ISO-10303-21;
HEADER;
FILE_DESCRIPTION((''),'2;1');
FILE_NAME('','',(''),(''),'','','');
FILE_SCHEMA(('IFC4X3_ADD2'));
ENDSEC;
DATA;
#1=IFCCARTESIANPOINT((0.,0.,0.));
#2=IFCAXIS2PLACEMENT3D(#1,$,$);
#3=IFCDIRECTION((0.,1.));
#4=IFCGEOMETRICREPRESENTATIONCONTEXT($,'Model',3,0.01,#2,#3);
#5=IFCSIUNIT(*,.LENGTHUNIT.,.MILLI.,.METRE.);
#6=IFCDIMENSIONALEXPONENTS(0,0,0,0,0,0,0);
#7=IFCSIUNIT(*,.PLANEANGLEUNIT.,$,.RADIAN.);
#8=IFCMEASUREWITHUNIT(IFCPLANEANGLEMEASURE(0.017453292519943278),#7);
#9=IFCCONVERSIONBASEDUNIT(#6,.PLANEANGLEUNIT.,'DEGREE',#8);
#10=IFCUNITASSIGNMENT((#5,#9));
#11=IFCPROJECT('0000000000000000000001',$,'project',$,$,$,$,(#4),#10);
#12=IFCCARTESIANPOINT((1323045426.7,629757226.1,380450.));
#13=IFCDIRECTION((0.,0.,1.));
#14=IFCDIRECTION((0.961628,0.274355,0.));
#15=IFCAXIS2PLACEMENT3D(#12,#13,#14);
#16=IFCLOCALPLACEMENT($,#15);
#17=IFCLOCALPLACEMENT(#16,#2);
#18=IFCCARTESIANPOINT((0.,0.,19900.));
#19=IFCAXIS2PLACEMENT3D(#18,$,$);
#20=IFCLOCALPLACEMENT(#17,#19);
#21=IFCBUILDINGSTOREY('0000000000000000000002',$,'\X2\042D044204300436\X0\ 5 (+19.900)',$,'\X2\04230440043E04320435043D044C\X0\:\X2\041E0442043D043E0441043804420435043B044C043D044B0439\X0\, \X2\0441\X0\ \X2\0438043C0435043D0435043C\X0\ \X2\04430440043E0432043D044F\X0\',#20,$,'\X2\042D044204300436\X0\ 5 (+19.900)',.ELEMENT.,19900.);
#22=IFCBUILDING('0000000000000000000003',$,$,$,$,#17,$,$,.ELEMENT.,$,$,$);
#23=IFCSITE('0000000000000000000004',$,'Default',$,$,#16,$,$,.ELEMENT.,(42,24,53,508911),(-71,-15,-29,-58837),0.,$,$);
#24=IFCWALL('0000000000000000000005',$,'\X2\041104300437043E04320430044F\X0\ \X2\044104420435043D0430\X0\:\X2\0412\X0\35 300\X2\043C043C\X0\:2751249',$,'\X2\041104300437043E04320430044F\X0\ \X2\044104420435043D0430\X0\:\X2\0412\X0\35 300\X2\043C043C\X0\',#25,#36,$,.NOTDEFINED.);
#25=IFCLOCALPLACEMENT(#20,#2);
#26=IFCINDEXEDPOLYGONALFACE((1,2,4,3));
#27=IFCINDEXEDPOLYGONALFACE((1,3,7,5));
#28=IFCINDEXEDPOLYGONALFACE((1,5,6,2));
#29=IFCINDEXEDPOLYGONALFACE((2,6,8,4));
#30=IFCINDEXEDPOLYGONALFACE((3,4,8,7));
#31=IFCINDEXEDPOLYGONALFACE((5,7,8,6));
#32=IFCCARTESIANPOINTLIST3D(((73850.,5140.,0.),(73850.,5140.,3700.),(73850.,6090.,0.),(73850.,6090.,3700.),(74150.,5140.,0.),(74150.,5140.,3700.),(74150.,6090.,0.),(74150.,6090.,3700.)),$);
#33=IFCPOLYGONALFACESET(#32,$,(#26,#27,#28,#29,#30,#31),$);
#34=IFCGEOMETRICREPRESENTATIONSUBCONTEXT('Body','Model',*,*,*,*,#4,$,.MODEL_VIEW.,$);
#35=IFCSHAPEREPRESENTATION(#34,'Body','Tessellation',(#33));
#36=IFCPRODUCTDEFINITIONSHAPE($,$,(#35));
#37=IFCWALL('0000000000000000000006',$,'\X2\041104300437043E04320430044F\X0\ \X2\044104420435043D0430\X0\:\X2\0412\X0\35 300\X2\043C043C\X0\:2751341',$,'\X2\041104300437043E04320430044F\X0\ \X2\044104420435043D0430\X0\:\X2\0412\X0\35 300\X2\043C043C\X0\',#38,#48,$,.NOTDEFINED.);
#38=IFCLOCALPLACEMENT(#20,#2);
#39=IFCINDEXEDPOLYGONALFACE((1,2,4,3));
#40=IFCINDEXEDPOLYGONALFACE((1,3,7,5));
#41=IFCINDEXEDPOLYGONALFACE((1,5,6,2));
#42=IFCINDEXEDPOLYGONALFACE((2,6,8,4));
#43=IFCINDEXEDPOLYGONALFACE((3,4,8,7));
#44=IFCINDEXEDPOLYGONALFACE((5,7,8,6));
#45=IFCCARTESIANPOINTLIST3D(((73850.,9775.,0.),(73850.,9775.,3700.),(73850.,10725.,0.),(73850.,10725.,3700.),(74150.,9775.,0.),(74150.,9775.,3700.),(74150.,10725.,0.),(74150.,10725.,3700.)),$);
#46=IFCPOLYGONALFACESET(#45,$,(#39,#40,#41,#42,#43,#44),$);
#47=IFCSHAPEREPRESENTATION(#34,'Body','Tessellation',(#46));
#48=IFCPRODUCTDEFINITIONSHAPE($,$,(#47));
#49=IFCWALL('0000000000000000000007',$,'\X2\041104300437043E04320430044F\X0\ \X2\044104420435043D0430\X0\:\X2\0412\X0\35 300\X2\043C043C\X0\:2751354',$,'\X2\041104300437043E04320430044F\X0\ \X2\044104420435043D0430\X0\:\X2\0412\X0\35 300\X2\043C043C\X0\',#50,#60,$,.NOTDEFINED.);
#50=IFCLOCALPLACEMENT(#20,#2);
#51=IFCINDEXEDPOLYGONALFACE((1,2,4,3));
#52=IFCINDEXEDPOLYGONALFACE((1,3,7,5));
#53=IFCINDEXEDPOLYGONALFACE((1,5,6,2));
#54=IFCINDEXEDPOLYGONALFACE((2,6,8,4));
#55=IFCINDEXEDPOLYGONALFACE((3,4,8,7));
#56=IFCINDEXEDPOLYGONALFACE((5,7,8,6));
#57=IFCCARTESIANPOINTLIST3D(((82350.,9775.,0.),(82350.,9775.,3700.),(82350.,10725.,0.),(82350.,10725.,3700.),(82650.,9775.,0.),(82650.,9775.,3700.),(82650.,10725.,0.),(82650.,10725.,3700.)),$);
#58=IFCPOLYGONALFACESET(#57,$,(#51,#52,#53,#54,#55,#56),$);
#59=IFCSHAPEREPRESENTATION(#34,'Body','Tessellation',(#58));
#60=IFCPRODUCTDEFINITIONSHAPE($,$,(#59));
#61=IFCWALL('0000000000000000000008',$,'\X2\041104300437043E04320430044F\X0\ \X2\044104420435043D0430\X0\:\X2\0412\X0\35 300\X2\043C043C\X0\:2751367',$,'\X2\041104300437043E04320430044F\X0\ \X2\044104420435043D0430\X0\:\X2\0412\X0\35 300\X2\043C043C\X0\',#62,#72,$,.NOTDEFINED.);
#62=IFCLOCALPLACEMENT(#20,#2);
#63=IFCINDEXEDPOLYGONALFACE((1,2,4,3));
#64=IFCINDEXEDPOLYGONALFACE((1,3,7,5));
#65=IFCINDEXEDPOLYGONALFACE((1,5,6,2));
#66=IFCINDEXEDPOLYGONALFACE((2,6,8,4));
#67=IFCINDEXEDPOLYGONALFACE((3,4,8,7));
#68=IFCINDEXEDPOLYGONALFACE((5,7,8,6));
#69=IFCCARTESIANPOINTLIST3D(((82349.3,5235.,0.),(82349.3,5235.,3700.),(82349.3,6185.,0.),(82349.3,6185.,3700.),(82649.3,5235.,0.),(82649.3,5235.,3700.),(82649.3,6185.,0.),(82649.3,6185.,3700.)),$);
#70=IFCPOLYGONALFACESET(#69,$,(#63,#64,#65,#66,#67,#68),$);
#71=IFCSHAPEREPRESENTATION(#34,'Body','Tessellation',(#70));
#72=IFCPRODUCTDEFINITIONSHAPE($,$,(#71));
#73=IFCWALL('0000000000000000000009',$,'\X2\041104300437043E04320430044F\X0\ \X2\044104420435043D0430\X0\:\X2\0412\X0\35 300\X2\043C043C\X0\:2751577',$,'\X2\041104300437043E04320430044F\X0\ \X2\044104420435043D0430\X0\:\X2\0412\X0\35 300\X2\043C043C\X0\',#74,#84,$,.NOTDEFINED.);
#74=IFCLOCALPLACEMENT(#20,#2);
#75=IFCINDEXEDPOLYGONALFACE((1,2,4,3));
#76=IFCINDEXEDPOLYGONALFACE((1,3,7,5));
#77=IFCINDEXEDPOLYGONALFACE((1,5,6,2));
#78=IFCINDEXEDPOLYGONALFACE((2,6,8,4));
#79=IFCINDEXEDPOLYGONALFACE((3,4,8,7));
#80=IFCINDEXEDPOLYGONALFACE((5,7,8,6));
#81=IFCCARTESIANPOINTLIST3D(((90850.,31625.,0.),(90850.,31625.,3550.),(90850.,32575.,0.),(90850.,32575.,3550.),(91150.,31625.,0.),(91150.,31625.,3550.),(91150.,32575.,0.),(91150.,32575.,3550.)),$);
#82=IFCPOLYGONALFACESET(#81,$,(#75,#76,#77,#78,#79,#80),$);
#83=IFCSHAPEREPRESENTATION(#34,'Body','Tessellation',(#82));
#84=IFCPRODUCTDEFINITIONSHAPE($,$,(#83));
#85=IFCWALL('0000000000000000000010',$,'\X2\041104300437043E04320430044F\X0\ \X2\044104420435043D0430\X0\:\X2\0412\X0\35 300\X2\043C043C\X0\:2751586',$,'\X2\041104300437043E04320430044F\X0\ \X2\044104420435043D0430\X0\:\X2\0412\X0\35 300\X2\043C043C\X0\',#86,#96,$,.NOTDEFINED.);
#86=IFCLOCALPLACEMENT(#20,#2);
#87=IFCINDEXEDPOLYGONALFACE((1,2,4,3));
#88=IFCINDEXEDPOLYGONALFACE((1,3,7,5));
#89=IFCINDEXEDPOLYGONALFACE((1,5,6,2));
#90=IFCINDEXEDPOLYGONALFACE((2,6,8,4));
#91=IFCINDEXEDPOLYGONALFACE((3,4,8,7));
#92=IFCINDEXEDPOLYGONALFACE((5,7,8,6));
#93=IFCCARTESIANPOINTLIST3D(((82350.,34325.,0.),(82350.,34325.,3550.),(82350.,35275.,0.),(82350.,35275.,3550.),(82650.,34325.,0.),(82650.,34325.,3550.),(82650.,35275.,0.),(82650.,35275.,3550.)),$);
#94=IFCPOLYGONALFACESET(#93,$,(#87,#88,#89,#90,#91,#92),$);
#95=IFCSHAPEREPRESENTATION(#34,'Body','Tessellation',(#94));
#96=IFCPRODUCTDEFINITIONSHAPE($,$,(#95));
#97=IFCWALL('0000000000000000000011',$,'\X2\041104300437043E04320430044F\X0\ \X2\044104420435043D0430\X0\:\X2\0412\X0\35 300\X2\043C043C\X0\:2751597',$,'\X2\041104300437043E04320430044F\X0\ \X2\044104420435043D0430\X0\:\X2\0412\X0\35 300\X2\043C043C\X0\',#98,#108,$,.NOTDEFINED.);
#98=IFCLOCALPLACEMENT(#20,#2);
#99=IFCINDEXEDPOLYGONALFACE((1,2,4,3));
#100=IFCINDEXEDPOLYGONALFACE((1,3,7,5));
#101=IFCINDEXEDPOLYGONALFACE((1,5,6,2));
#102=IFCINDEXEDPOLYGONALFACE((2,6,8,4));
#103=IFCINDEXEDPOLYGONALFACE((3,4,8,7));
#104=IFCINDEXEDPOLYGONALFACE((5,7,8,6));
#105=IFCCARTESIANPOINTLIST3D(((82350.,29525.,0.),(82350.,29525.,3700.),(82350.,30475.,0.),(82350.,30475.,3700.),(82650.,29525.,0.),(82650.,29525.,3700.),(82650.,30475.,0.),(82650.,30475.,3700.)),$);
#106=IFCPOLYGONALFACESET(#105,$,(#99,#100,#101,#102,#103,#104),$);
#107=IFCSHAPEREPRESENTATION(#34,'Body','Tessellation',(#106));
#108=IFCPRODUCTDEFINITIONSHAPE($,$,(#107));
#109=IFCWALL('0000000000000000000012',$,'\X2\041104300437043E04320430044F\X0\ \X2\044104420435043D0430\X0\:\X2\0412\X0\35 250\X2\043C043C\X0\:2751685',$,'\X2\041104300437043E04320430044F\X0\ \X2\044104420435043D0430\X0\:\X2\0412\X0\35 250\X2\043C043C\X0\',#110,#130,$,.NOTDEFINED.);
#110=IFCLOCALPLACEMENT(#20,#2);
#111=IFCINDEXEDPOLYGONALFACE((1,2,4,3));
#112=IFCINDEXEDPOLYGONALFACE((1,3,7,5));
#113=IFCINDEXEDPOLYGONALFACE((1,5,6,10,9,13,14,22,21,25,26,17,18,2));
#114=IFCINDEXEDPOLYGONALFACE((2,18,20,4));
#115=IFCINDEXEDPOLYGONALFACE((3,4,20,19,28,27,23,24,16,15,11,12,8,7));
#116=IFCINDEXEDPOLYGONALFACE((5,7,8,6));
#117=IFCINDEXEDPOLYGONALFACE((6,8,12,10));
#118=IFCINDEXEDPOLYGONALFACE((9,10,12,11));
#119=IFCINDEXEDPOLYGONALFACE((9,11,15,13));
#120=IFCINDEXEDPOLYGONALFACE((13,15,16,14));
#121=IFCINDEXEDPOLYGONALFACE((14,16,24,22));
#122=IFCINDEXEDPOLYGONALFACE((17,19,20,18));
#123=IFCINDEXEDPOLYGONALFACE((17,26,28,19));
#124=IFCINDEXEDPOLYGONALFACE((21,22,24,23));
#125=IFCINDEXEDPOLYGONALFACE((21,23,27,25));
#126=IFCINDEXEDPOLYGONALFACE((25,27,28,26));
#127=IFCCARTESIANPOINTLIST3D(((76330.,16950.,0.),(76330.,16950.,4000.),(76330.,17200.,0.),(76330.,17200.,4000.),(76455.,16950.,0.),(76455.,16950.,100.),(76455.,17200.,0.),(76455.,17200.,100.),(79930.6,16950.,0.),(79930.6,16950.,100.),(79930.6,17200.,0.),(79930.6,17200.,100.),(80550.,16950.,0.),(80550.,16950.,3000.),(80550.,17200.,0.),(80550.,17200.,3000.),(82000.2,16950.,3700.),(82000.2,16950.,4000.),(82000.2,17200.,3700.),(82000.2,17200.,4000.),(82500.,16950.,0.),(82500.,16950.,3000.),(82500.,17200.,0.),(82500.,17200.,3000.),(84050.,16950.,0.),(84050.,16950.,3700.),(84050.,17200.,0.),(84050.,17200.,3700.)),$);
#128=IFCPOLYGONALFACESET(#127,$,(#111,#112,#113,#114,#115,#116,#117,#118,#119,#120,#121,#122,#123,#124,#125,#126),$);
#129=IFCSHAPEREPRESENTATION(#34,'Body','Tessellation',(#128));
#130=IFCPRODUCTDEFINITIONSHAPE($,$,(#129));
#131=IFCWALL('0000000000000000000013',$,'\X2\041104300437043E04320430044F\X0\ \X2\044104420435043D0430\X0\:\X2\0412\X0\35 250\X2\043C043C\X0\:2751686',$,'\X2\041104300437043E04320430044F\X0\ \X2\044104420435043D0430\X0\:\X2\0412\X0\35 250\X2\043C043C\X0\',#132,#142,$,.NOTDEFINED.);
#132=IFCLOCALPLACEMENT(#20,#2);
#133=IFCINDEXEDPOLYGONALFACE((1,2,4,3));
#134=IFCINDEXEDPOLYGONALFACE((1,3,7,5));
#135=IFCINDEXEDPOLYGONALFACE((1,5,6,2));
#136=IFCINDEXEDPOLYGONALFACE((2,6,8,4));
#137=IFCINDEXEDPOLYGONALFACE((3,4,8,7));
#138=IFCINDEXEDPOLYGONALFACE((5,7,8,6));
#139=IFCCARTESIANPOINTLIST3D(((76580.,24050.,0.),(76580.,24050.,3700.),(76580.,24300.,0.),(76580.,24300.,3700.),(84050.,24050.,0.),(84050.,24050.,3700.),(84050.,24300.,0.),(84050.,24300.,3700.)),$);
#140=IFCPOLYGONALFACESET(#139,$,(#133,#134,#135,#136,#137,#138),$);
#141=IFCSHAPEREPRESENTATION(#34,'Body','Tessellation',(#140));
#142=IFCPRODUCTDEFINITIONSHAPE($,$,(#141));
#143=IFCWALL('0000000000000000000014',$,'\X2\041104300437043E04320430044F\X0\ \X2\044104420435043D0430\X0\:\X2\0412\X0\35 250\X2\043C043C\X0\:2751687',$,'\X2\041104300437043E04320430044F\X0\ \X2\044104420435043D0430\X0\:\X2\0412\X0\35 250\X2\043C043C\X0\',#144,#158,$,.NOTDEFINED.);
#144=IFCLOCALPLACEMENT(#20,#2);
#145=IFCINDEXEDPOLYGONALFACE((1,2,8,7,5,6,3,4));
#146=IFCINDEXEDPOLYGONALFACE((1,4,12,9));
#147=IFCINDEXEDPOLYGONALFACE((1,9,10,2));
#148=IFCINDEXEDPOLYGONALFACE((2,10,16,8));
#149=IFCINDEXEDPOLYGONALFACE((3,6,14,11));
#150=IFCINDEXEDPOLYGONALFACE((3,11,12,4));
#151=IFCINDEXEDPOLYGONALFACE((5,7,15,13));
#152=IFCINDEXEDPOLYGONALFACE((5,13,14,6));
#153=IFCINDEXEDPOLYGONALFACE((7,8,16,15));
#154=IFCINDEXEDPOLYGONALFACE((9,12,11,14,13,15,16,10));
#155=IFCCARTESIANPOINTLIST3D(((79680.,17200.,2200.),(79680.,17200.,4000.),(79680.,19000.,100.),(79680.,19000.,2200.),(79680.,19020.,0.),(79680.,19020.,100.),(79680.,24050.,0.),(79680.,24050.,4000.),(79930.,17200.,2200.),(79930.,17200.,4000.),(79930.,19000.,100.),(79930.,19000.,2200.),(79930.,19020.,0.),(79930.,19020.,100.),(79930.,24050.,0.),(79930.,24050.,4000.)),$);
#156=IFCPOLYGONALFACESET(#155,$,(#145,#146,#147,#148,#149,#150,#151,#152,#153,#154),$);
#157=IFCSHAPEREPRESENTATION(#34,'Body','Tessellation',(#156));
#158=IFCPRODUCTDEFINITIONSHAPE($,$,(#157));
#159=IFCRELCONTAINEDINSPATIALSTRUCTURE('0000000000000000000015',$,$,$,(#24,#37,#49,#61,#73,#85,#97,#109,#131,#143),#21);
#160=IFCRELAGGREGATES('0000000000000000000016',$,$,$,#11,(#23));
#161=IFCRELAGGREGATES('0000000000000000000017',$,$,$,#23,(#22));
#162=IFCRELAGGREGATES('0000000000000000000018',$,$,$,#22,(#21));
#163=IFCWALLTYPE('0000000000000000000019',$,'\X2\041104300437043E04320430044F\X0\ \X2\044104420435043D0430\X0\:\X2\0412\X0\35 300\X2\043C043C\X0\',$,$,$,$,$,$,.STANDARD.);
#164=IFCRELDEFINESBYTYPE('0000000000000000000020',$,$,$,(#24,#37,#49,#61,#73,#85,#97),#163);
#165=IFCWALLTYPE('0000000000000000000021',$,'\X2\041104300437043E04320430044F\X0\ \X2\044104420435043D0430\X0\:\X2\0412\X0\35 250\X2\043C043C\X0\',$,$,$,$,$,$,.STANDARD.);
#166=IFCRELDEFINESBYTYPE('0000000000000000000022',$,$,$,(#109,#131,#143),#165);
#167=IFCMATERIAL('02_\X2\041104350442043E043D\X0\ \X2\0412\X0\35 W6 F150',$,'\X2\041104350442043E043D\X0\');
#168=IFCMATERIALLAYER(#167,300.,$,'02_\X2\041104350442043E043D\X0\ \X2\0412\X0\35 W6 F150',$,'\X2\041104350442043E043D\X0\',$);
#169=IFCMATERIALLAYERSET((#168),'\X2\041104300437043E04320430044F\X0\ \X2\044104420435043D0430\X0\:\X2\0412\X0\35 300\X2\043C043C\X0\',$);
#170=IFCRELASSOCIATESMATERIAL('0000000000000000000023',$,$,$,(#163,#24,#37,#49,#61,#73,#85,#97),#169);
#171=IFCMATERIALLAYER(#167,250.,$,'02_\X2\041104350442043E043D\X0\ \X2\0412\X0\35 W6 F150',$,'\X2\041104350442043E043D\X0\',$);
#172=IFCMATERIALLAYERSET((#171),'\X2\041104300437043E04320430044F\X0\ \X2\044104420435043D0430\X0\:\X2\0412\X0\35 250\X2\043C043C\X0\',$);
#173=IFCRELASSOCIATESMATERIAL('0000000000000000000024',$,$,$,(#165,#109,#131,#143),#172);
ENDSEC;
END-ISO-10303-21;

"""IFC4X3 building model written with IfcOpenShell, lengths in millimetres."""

from ifc_helpers import new_model, entity, si_unit, converted_unit, direction, frame, frame_2d, origin, origin_2d_with_axis, place, context, subcontext, project, spatial, rectangle, extrude, material, layer, layer_set, type_object, element, save


model = new_model("IFC4X3")

# Units and contexts
model_context = context("Model", 3, precision=0.01, world=origin(), true_north=direction((0.0, 1.0)))
body_context = subcontext(model_context, "Body", "Model", "MODEL_VIEW")
ifc_project = project(units=[si_unit("LENGTHUNIT", "METRE", prefix="MILLI"), converted_unit("PLANEANGLEUNIT", "DEGREE", entity("IfcPlaneAngleMeasure", 0.017453292519943278), si_unit("PLANEANGLEUNIT", "RADIAN"), dimensions=[0, 0, 0, 0, 0, 0, 0])], contexts=[model_context])

# Site, building, storey
site_placement = place(None, frame((1323045426.7, 629757226.1, 380450.0), z_axis=(0.0, 0.0, 1.0), x_axis=(0.961628, 0.274355, 0.0)))
site = spatial("IfcSite", under=ifc_project, at=site_placement, Name="Default", CompositionType="ELEMENT", RefLatitude=(42, 24, 53, 508911), RefLongitude=(-71, -15, -29, -58837), RefElevation=0.0)
building_placement = place(site_placement, origin())
building = spatial("IfcBuilding", under=site, at=building_placement, CompositionType="ELEMENT")
storey_placement = place(building_placement, frame((0.0, 0.0, 19900.0)))
storey = spatial("IfcBuildingStorey", under=building, at=storey_placement, Name="Этаж 5 (+19.900)", ObjectType="Уровень:Относительный, с именем уровня", LongName="Этаж 5 (+19.900)", CompositionType="ELEMENT", Elevation=19900.0)

# Shared definitions
ifc_material = material(Name="02_Бетон В35 W6 F150", Category="Бетон")

# Walls
ifc_layer_1 = layer(ifc_material, 300.0, Name="02_Бетон В35 W6 F150", Category="Бетон")
ifc_layer_set_1 = layer_set([ifc_layer_1], Name="Базовая стена:В35 300мм")
wall_type_1 = type_object("IfcWallType", Name="Базовая стена:В35 300мм", PredefinedType="STANDARD", material=ifc_layer_set_1)
for number, where, z_axis, x_axis, name in (
    (1, (74000.0, 5140.0, 0.0), (0.0, 0.0, 1.0), (0.0, 1.0, 0.0), "Базовая стена:В35 300мм:2751249"),
    (2, (74000.0, 9775.0, 0.0), (0.0, 0.0, 1.0), (0.0, 1.0, 0.0), "Базовая стена:В35 300мм:2751341"),
    (3, (82500.0, 9775.0, 0.0), (0.0, 0.0, 1.0), (0.0, 1.0, 0.0), "Базовая стена:В35 300мм:2751354"),
    (4, (82499.3, 5235.0, 0.0), (0.0, 0.0, 1.0), (0.0, 1.0, 0.0), "Базовая стена:В35 300мм:2751367"),
):
    element("IfcWall", number, at=place(storey_placement, frame(where, z_axis=z_axis, x_axis=x_axis)), inside=storey, type_object=wall_type_1, material=ifc_layer_set_1, Name=name, ObjectType="Базовая стена:В35 300мм", PredefinedType="NOTDEFINED", context=body_context, shape_type="SweptSolid", body=[
        extrude(rectangle(XDim=950.0, YDim=300.0, at=frame_2d((475.0, 0.0), x_axis=(-1.0, 0.0))), origin(), (0.0, 0.0, 1.0), 3700.0),
    ])
for number, where, z_axis, x_axis, name in (
    (5, (91000.0, 31625.0, 0.0), (0.0, 0.0, 1.0), (0.0, 1.0, 0.0), "Базовая стена:В35 300мм:2751577"),
    (6, (82500.0, 34325.0, 0.0), (0.0, 0.0, 1.0), (0.0, 1.0, 0.0), "Базовая стена:В35 300мм:2751586"),
):
    element("IfcWall", number, at=place(storey_placement, frame(where, z_axis=z_axis, x_axis=x_axis)), inside=storey, type_object=wall_type_1, material=ifc_layer_set_1, Name=name, ObjectType="Базовая стена:В35 300мм", PredefinedType="NOTDEFINED", context=body_context, shape_type="SweptSolid", body=[
        extrude(rectangle(XDim=950.0, YDim=300.0, at=frame_2d((475.0, 0.0), x_axis=(-1.0, 0.0))), origin(), (0.0, 0.0, 1.0), 3550.0),
    ])
wall_1_placement = place(storey_placement, frame((82500.0, 29525.0, 0.0), z_axis=(0.0, 0.0, 1.0), x_axis=(0.0, 1.0, 0.0)))
element("IfcWall", 7, at=wall_1_placement, inside=storey, type_object=wall_type_1, material=ifc_layer_set_1, Name="Базовая стена:В35 300мм:2751597", ObjectType="Базовая стена:В35 300мм", PredefinedType="NOTDEFINED", context=body_context, shape_type="SweptSolid", body=[
    extrude(rectangle(XDim=950.0, YDim=300.0, at=frame_2d((475.0, 0.0), x_axis=(-1.0, 0.0))), origin(), (0.0, 0.0, 1.0), 3700.0),
])

# Wall, openings
ifc_layer_2 = layer(ifc_material, 250.0, Name="02_Бетон В35 W6 F150", Category="Бетон")
ifc_layer_set_2 = layer_set([ifc_layer_2], Name="Базовая стена:В35 250мм")
wall_type_2 = type_object("IfcWallType", Name="Базовая стена:В35 250мм", PredefinedType="STANDARD", material=ifc_layer_set_2)
wall_2_placement = place(storey_placement, frame((84050.0, 17075.0, 0.0), z_axis=(0.0, 0.0, 1.0), x_axis=(-1.0, 0.0, 0.0)))
wall_2 = element("IfcWall", 8, at=wall_2_placement, inside=storey, type_object=wall_type_2, material=ifc_layer_set_2, Name="Базовая стена:В35 250мм:2751685", ObjectType="Базовая стена:В35 250мм", PredefinedType="NOTDEFINED", context=body_context, shape_type="SweptSolid", body=[
    extrude(rectangle(XDim=7720.0, YDim=250.0, at=frame_2d((3860.0, 0.0), x_axis=(-1.0, 0.0))), origin(), (0.0, 0.0, 1.0), 4000.0),
])
opening_1_placement = place(wall_2_placement, frame((84050.0, 17075.0, 0.0)))
element("IfcOpeningElement", 9, at=opening_1_placement, cuts=wall_2, PredefinedType="OPENING", context=body_context, shape_type="SweptSolid", body=[
    extrude(rectangle(XDim=2200.0, YDim=250.0, at=frame_2d((0.0, 0.0), x_axis=(0.0, 1.0))), frame((-79805.0, -19000.0, 1100.0), z_axis=(0.0, 1.0, 0.0), x_axis=(-1.0, 0.0, 0.0)), (0.0, 0.0, 1.0), 1800.0),
])
opening_2_placement = place(wall_2_placement, origin())
element("IfcOpeningElement", 10, at=opening_2_placement, cuts=wall_2, PredefinedType="OPENING", context=body_context, shape_type="SweptSolid", body=[
    extrude(rectangle(XDim=100.0, YDim=3475.6, at=frame_2d((0.0, 0.0), x_axis=(0.0, 1.0))), frame((5857.2, 125.0, 50.0), z_axis=(0.0, -1.0, 0.0), x_axis=(-1.0, 0.0, 0.0)), (0.0, 0.0, 1.0), 250.0),
])
opening_3_placement = place(wall_2_placement, origin())
element("IfcOpeningElement", 11, at=opening_3_placement, cuts=wall_2, PredefinedType="OPENING", context=body_context, shape_type="SweptSolid", body=[
    extrude(rectangle(XDim=300.0, YDim=2049.8, at=frame_2d((0.0, 0.0), x_axis=(0.0, 1.0))), frame((1024.9, 125.0, 3850.0), z_axis=(0.0, -1.0, 0.0), x_axis=(1.0, 0.0, 0.0)), (0.0, 0.0, 1.0), 250.0),
])
opening_4_placement = place(wall_2_placement, frame((84050.0, 17075.0, 0.0), z_axis=(0.0, 0.0, 1.0), x_axis=(-1.0, 0.0, 0.0)))
element("IfcOpeningElement", 12, at=opening_4_placement, cuts=wall_2, PredefinedType="OPENING", context=body_context, shape_type="SweptSolid", body=[
    extrude(rectangle(XDim=3000.0, YDim=1950.0, at=origin_2d_with_axis()), frame((81525.0, 18724.0, 1500.0), z_axis=(0.0, -1.0, 0.0), x_axis=(0.0, 0.0, -1.0)), (0.0, 0.0, 1.0), 3048.0),
])

# Wall
wall_3_placement = place(storey_placement, frame((84050.0, 24175.0, 0.0), z_axis=(0.0, 0.0, 1.0), x_axis=(-1.0, 0.0, 0.0)))
element("IfcWall", 13, at=wall_3_placement, inside=storey, type_object=wall_type_2, material=ifc_layer_set_2, Name="Базовая стена:В35 250мм:2751686", ObjectType="Базовая стена:В35 250мм", PredefinedType="NOTDEFINED", context=body_context, shape_type="SweptSolid", body=[
    extrude(rectangle(XDim=7470.0, YDim=250.0, at=frame_2d((3735.0, 0.0), x_axis=(-1.0, 0.0))), origin(), (0.0, 0.0, 1.0), 3700.0),
])

# Wall, openings
wall_4_placement = place(storey_placement, frame((79805.0, 24050.0, 0.0), z_axis=(0.0, 0.0, 1.0), x_axis=(0.0, -1.0, 0.0)))
wall_4 = element("IfcWall", 14, at=wall_4_placement, inside=storey, type_object=wall_type_2, material=ifc_layer_set_2, Name="Базовая стена:В35 250мм:2751687", ObjectType="Базовая стена:В35 250мм", PredefinedType="NOTDEFINED", context=body_context, shape_type="SweptSolid", body=[
    extrude(rectangle(XDim=6850.0, YDim=250.0, at=frame_2d((3425.0, 0.0), x_axis=(-1.0, 0.0))), origin(), (0.0, 0.0, 1.0), 4000.0),
])
opening_5_placement = place(wall_4_placement, origin())
element("IfcOpeningElement", 15, at=opening_5_placement, cuts=wall_4, PredefinedType="OPENING", context=body_context, shape_type="SweptSolid", body=[
    extrude(rectangle(XDim=100.0, YDim=1945.0, at=frame_2d((0.0, 0.0), x_axis=(0.0, 1.0))), frame((6002.5, 125.0, 50.0), z_axis=(0.0, -1.0, 0.0), x_axis=(-1.0, 0.0, 0.0)), (0.0, 0.0, 1.0), 250.0),
])
opening_6_placement = place(wall_4_placement, frame((24050.0, -79805.0, 0.0), z_axis=(0.0, 0.0, 1.0), x_axis=(0.0, 1.0, 0.0)))
element("IfcOpeningElement", 16, at=opening_6_placement, cuts=wall_4, PredefinedType="OPENING", context=body_context, shape_type="SweptSolid", body=[
    extrude(rectangle(XDim=2200.0, YDim=1800.0, at=frame_2d((0.0, 0.0), x_axis=(0.0, 1.0))), frame((78406.0, 18100.0, 1100.0), z_axis=(1.0, 0.0, 0.0), x_axis=(0.0, -1.0, 0.0)), (0.0, 0.0, 1.0), 3048.0),
])

save(model, "model.ifc")
